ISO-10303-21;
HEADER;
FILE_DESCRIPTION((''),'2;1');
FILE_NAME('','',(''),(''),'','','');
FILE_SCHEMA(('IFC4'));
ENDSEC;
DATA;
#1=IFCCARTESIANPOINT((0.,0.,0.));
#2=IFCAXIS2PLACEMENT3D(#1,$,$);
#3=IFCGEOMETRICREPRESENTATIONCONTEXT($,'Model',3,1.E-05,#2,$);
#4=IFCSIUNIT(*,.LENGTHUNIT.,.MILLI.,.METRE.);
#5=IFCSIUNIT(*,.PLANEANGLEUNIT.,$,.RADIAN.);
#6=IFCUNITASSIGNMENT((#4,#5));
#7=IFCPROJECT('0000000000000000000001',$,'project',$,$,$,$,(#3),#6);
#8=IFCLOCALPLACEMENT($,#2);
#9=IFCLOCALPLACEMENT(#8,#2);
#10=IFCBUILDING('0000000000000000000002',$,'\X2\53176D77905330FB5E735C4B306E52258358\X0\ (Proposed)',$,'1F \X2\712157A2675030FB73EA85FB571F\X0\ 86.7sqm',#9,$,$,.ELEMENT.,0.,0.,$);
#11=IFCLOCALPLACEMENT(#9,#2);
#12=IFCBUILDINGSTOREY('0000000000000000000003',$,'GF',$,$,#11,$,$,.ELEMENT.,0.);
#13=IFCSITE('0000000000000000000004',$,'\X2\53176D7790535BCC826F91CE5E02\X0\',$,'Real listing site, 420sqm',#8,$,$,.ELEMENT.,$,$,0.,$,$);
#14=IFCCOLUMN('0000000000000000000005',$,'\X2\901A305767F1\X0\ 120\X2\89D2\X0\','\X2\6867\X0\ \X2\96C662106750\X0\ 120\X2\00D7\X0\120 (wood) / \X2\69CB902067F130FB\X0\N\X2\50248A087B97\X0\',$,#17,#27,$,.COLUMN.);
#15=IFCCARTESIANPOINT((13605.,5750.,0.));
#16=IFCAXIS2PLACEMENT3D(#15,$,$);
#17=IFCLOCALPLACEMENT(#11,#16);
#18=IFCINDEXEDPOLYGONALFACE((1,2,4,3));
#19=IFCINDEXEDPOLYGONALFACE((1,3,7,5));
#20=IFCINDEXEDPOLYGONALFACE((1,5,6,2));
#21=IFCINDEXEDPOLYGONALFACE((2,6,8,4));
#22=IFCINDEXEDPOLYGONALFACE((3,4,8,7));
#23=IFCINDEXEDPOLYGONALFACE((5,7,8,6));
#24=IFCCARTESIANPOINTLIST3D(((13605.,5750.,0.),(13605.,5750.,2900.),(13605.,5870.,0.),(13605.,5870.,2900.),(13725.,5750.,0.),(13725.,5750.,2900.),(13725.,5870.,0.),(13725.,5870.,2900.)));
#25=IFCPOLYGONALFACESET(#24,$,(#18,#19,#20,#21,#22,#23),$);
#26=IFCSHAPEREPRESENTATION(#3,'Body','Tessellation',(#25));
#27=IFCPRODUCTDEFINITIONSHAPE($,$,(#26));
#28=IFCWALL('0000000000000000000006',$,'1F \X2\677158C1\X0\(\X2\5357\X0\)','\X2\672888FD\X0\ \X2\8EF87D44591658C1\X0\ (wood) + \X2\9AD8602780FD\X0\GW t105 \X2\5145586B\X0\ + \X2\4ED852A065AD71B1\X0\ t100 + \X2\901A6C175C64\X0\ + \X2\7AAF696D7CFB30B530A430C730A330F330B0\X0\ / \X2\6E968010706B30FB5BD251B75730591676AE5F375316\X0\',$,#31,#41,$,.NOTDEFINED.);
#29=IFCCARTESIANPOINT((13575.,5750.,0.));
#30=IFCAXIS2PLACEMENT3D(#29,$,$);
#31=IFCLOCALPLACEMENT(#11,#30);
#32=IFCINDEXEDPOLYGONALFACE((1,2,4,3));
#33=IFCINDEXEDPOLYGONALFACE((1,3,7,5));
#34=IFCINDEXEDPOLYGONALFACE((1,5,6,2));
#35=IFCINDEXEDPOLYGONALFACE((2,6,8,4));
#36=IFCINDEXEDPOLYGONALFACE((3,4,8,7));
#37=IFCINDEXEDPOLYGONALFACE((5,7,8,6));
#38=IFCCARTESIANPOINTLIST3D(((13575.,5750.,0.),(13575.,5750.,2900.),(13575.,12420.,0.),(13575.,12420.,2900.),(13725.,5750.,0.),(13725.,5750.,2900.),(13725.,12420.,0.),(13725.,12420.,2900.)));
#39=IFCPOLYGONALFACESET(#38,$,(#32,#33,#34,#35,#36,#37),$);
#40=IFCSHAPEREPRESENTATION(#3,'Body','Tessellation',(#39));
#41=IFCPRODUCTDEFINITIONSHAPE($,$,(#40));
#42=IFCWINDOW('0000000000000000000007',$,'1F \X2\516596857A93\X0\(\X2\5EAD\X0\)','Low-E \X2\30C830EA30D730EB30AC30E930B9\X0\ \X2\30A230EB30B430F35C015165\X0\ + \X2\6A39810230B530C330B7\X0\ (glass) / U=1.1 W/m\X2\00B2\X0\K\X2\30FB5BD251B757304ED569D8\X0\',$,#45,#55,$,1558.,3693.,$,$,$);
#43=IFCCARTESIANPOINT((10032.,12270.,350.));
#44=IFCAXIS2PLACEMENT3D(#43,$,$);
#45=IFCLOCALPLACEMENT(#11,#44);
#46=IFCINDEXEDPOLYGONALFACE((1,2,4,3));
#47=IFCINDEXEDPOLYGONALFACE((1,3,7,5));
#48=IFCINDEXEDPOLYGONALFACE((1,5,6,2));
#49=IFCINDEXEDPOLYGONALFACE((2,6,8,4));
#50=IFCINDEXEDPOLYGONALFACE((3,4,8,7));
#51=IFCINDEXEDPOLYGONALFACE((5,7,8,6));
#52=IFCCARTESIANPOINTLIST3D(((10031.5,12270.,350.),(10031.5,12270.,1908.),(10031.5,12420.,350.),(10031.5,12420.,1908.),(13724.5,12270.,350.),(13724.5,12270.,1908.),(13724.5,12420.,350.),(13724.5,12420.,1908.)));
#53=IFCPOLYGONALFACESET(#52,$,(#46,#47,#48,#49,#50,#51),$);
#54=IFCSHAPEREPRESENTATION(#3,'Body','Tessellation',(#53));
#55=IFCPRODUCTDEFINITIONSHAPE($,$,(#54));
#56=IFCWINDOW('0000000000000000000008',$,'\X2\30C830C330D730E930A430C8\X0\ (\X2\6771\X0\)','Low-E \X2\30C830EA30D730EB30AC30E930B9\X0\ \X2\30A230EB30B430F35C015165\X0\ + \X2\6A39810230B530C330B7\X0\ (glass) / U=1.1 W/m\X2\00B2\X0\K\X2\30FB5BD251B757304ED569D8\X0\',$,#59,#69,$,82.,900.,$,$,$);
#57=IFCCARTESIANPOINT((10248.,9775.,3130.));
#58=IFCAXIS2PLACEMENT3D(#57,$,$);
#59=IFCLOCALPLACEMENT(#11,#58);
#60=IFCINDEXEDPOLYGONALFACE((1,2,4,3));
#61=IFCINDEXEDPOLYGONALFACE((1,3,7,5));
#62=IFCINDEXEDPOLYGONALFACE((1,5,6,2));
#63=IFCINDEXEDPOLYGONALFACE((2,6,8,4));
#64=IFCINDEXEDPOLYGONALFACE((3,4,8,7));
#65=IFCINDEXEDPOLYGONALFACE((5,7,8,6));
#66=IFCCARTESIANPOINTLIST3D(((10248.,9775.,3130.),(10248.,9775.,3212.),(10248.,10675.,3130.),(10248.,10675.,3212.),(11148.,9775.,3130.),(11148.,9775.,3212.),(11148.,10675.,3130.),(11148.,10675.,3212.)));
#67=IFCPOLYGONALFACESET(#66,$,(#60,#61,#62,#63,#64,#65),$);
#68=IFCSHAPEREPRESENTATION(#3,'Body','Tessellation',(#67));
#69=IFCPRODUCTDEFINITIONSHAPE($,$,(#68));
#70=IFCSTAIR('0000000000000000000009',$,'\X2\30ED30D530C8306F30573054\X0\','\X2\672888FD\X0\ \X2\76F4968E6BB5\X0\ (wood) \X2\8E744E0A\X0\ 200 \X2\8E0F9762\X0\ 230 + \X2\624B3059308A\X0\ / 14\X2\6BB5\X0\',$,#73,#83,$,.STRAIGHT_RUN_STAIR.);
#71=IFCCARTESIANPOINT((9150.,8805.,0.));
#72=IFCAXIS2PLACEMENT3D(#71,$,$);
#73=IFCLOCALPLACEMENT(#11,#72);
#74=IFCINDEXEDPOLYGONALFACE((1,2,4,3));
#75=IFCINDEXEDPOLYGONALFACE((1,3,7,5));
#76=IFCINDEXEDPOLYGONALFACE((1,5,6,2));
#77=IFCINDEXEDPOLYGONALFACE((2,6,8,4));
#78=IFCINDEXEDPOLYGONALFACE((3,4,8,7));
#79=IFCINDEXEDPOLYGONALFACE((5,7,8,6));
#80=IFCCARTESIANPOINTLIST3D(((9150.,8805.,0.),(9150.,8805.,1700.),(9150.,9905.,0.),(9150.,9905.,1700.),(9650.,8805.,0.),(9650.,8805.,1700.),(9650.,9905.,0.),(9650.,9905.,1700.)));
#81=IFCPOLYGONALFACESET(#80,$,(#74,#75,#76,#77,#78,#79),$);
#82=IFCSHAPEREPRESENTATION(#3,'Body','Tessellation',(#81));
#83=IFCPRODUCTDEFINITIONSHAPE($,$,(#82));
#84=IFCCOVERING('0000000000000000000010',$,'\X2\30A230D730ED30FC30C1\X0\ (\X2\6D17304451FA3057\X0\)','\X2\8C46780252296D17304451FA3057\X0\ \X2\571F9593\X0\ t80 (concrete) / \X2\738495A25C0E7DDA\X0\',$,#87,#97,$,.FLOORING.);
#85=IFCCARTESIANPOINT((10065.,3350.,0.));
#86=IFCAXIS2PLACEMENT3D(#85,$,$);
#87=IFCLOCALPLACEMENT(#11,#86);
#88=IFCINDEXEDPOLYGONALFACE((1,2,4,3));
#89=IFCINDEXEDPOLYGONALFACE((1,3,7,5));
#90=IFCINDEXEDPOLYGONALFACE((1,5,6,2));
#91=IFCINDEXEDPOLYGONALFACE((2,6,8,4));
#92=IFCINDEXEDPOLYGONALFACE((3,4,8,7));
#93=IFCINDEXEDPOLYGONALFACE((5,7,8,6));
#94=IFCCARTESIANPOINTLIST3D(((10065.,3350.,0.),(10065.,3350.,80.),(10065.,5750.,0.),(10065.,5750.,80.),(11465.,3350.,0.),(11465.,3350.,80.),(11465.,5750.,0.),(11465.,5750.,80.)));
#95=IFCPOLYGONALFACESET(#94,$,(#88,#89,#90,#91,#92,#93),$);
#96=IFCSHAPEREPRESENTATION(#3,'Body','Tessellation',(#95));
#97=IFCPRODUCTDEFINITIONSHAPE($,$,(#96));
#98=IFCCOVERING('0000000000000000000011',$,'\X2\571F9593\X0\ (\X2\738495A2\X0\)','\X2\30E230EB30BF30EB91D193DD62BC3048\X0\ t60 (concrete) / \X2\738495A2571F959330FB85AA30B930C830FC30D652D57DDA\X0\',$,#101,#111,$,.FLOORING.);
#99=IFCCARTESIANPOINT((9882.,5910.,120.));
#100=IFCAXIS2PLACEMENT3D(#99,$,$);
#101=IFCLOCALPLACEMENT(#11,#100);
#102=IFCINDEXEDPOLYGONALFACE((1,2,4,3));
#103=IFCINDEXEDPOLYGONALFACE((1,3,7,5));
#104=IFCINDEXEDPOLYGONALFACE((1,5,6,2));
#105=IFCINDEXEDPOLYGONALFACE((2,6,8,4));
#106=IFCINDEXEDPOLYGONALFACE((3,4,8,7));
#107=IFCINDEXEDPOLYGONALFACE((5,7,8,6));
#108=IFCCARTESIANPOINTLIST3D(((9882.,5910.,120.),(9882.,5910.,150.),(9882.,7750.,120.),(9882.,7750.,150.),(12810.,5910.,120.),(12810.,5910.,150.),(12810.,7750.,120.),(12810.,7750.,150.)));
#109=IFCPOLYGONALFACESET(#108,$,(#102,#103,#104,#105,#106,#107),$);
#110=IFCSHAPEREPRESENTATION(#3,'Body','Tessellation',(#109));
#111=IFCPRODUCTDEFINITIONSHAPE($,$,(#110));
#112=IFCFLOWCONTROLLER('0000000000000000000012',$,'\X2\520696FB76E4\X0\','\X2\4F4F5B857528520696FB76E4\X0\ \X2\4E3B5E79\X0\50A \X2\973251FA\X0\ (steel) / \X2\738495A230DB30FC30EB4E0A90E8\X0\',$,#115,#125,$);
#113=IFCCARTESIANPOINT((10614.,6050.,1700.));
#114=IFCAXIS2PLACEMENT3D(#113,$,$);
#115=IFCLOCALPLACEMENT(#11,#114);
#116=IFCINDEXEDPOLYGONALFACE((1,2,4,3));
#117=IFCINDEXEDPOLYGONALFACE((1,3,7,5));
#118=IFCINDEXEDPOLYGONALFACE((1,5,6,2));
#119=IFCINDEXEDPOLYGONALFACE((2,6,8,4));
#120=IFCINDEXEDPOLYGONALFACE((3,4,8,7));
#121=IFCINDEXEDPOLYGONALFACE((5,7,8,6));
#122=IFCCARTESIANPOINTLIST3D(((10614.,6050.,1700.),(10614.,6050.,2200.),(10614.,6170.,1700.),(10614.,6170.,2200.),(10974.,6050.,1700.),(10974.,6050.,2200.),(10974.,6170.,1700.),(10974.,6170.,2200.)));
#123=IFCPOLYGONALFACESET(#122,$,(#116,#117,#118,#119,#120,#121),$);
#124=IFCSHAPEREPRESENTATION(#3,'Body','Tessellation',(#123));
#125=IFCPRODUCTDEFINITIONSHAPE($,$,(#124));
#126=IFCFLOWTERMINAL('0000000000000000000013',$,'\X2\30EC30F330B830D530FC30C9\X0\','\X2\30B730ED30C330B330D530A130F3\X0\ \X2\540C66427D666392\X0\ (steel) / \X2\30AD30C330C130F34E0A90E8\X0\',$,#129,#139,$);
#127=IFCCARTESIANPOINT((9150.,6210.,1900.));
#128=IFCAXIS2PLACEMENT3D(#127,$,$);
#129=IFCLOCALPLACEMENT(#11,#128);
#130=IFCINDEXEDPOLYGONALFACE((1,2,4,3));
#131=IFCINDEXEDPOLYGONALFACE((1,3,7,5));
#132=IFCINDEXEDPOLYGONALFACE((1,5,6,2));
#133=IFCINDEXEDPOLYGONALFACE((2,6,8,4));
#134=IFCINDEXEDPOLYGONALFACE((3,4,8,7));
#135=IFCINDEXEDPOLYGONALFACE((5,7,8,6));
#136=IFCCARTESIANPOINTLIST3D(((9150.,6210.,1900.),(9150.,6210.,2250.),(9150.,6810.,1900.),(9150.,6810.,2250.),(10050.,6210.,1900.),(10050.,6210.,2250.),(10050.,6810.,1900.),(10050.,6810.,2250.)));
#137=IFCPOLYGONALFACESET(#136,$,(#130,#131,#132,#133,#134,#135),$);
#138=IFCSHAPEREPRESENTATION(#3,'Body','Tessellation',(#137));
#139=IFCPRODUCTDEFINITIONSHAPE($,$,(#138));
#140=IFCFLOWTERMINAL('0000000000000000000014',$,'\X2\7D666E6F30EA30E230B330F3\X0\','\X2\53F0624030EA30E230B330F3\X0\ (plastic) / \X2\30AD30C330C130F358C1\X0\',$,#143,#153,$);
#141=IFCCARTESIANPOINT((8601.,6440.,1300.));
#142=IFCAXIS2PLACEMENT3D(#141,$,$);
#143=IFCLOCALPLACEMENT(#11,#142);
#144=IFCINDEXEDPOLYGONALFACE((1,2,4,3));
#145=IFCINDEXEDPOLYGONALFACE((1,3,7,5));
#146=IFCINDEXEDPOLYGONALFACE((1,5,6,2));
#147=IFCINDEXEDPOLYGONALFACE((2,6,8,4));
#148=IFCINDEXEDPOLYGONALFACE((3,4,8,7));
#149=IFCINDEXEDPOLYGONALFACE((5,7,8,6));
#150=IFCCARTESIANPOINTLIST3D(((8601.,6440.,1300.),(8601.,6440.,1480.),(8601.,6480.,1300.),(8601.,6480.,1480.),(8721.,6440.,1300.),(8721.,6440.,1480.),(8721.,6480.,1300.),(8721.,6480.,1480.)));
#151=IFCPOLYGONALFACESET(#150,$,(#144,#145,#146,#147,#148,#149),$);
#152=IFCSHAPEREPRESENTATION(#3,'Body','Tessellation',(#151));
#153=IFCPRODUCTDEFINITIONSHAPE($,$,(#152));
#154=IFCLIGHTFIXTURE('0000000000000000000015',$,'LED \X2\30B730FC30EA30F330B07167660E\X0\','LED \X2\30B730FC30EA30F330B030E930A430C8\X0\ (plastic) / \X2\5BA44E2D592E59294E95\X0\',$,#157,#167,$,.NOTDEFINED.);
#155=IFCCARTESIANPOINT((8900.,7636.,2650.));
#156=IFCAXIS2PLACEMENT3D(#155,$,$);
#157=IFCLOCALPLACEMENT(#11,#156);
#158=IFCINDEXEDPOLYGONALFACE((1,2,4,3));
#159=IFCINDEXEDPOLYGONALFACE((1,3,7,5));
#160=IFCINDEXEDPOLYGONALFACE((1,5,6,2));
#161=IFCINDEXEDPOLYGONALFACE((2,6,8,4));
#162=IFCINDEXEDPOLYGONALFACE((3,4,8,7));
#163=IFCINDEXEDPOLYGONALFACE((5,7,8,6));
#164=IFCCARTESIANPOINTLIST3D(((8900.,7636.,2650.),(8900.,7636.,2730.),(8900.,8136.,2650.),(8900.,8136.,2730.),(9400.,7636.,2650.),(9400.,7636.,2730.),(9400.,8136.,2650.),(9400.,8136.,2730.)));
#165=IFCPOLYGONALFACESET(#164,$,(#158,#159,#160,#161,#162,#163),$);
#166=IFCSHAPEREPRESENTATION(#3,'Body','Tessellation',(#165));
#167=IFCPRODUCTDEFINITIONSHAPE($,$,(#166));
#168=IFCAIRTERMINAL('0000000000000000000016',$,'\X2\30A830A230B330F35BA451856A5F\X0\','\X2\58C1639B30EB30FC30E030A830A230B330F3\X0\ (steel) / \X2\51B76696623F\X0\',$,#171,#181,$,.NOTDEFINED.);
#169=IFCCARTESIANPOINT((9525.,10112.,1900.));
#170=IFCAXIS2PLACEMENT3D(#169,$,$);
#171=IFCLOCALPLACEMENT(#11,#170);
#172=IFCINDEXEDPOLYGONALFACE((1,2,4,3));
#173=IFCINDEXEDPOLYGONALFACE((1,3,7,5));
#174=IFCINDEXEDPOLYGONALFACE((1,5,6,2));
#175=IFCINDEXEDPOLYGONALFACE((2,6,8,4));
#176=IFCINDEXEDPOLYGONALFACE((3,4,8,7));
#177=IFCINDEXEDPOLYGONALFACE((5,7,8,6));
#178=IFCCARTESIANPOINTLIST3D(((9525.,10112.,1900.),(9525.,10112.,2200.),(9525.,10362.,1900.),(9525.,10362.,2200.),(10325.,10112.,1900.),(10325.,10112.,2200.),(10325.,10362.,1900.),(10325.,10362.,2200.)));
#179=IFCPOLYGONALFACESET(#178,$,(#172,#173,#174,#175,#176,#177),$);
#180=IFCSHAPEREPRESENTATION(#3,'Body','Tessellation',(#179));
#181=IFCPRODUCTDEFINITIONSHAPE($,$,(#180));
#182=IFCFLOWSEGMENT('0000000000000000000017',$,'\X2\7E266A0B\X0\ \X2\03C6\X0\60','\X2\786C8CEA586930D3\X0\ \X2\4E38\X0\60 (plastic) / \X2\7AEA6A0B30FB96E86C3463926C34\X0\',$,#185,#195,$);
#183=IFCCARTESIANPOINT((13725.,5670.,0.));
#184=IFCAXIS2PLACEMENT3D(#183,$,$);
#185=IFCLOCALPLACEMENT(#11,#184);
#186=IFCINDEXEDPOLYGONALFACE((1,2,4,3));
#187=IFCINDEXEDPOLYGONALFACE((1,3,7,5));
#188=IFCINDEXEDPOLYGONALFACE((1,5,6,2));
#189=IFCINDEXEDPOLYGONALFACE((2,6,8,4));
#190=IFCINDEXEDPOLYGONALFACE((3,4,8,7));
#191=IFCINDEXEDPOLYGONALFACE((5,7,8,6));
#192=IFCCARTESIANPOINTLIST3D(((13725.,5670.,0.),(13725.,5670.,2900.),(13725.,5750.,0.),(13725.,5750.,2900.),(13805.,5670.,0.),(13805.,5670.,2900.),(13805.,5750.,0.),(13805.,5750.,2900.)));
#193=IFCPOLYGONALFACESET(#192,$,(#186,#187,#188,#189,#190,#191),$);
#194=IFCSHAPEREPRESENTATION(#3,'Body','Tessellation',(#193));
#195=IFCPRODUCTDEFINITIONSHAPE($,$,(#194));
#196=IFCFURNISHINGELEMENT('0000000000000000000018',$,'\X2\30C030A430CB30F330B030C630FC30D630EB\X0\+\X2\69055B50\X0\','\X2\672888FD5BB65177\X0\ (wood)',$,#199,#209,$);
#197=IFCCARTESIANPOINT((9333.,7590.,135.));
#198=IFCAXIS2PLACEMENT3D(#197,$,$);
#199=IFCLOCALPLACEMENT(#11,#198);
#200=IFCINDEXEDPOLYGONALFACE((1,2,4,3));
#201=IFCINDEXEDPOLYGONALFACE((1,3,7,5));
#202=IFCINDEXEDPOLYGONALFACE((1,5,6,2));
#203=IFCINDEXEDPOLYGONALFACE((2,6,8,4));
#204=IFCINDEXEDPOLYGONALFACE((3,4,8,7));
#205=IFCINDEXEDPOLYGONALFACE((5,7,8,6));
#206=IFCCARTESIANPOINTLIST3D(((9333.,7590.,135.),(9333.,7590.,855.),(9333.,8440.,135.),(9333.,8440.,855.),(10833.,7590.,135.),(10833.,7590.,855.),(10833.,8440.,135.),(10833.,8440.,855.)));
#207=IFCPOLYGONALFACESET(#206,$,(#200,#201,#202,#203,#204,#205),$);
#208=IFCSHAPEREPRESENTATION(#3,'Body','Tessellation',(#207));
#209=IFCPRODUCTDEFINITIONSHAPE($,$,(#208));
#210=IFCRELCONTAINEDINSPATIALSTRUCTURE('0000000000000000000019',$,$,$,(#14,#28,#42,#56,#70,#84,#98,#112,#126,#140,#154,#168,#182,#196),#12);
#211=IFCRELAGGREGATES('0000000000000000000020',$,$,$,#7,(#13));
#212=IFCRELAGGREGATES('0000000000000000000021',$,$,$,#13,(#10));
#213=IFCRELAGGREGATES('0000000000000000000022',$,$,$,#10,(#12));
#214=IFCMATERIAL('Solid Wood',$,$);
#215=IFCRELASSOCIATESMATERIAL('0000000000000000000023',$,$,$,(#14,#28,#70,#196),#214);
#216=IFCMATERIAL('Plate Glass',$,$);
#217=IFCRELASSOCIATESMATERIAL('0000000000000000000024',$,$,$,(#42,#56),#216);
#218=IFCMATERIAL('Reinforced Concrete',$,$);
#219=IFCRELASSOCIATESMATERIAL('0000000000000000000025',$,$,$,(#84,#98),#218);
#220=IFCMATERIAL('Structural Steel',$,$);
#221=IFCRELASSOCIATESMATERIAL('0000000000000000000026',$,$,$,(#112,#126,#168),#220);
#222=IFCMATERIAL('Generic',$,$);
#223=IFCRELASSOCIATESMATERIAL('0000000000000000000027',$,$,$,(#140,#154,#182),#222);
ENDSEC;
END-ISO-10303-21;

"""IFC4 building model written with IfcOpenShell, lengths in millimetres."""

from ifc_helpers import new_model, si_unit, frame, frame_2d, origin, place, context, project, spatial, rectangle, extrude, material, element, fill, save


model = new_model("IFC4")

# Units and contexts
model_context = context("Model", 3, precision=1e-05, world=origin())
ifc_project = project(units=[si_unit("LENGTHUNIT", "METRE", prefix="MILLI"), si_unit("PLANEANGLEUNIT", "RADIAN")], contexts=[model_context])

# Site, building, storey
site_placement = place(None, origin())
site = spatial("IfcSite", under=ifc_project, at=site_placement, Name="北海道富良野市", ObjectType="Real listing site, 420sqm", CompositionType="ELEMENT", RefElevation=0.0)
building_placement = place(site_placement, origin())
building = spatial("IfcBuilding", under=site, at=building_placement, Name="北海道・平屋の別荘 (Proposed)", ObjectType="1F 無垢材・珪藻土 86.7sqm", CompositionType="ELEMENT", ElevationOfRefHeight=0.0, ElevationOfTerrain=0.0)
storey_placement = place(building_placement, origin())
storey = spatial("IfcBuildingStorey", under=building, at=storey_placement, Name="GF", CompositionType="ELEMENT", Elevation=0.0)

# Column
ifc_material_1 = material(Name="Solid Wood")
column_1_placement = place(storey_placement, frame((13605.0, 5750.0, 0.0)))
element("IfcColumn", 1, at=column_1_placement, inside=storey, material=ifc_material_1, Name="通し柱 120角", Description="桧 集成材 120×120 (wood) / 構造柱・N値計算", PredefinedType="COLUMN", context=model_context, shape_type="SweptSolid", body=[
    extrude(rectangle(XDim=120.0, YDim=120.0, at=frame_2d((60.0, 60.0))), frame((13605.0, 5750.0, 0.0)), (0.0, 0.0, 1.0), 2900.0),
])

# Wall, opening, window
wall_1_placement = place(storey_placement, frame((13575.0, 5750.0, 0.0)))
wall_1 = element("IfcWall", 2, at=wall_1_placement, inside=storey, material=ifc_material_1, Name="1F 東壁(南)", Description="木製 軸組外壁 (wood) + 高性能GW t105 充填 + 付加断熱 t100 + 通気層 + 窯業系サイディング / 準耐火・寒冷地外皮強化", PredefinedType="NOTDEFINED", context=model_context, shape_type="SweptSolid", body=[
    extrude(rectangle(XDim=150.0, YDim=6670.0, at=frame_2d((75.0, 3335.0))), frame((13575.0, 5750.0, 0.0)), (0.0, 0.0, 1.0), 2900.0),
])
opening_placement = place(storey_placement, frame((10032.0, 12270.0, 350.0)))
opening = element("IfcOpeningElement", 3, at=opening_placement, cuts=wall_1, PredefinedType="NOTDEFINED", context=model_context, shape_type="SweptSolid", body=[
    extrude(rectangle(XDim=3693.0, YDim=150.0, at=frame_2d((1846.0, 75.0))), frame((10032.0, 12270.0, 350.0)), (0.0, 0.0, 1.0), 1558.0),
])
ifc_material_2 = material(Name="Plate Glass")
window_1_placement = place(storey_placement, frame((10032.0, 12270.0, 350.0)))
window_1 = element("IfcWindow", 4, at=window_1_placement, inside=storey, material=ifc_material_2, Name="1F 入隅窓(庭)", Description="Low-E トリプルガラス アルゴン封入 + 樹脂サッシ (glass) / U=1.1 W/m²K・寒冷地仕様", OverallHeight=1558.0, OverallWidth=3693.0, context=model_context, shape_type="SweptSolid", body=[
    extrude(rectangle(XDim=3693.0, YDim=150.0, at=frame_2d((1846.0, 75.0))), frame((10032.0, 12270.0, 350.0)), (0.0, 0.0, 1.0), 1558.0),
])
fill(opening, window_1)

# Window
window_2_placement = place(storey_placement, frame((10248.0, 9775.0, 3130.0)))
element("IfcWindow", 5, at=window_2_placement, inside=storey, material=ifc_material_2, Name="トップライト (東)", Description="Low-E トリプルガラス アルゴン封入 + 樹脂サッシ (glass) / U=1.1 W/m²K・寒冷地仕様", OverallHeight=82.0, OverallWidth=900.0, context=model_context, shape_type="SweptSolid", body=[
    extrude(rectangle(XDim=900.0, YDim=900.0, at=frame_2d((450.0, 450.0))), frame((10248.0, 9775.0, 3130.0)), (0.0, 0.0, 1.0), 82.0),
])

# Stair
stair_placement = place(storey_placement, frame((9150.0, 8805.0, 0.0)))
element("IfcStair", 6, at=stair_placement, inside=storey, material=ifc_material_1, Name="ロフトはしご", Description="木製 直階段 (wood) 蹴上 200 踏面 230 + 手すり / 14段", PredefinedType="STRAIGHT_RUN_STAIR", context=model_context, shape_type="SweptSolid", body=[
    extrude(rectangle(XDim=500.0, YDim=1100.0, at=frame_2d((250.0, 550.0))), frame((9150.0, 8805.0, 0.0)), (0.0, 0.0, 1.0), 1700.0),
])

# Coverings
ifc_material_3 = material(Name="Reinforced Concrete")
covering_1_placement = place(storey_placement, frame((10065.0, 3350.0, 0.0)))
element("IfcCovering", 7, at=covering_1_placement, inside=storey, material=ifc_material_3, Name="アプローチ (洗い出し)", Description="豆砂利洗い出し 土間 t80 (concrete) / 玄関導線", PredefinedType="FLOORING", context=model_context, shape_type="SweptSolid", body=[
    extrude(rectangle(XDim=1400.0, YDim=2400.0, at=frame_2d((700.0, 1200.0))), frame((10065.0, 3350.0, 0.0)), (0.0, 0.0, 1.0), 80.0),
])
covering_2_placement = place(storey_placement, frame((9882.0, 5910.0, 120.0)))
element("IfcCovering", 8, at=covering_2_placement, inside=storey, material=ifc_material_3, Name="土間 (玄関)", Description="モルタル金鏝押え t60 (concrete) / 玄関土間・薪ストーブ動線", PredefinedType="FLOORING", context=model_context, shape_type="SweptSolid", body=[
    extrude(rectangle(XDim=2928.0, YDim=1840.0, at=frame_2d((1464.0, 920.0))), frame((9882.0, 5910.0, 120.0)), (0.0, 0.0, 1.0), 30.0),
])

# Flow controller
ifc_material_4 = material(Name="Structural Steel")
flow_controller_placement = place(storey_placement, frame((10614.0, 6050.0, 1700.0)))
element("IfcFlowController", 9, at=flow_controller_placement, inside=storey, material=ifc_material_4, Name="分電盤", Description="住宅用分電盤 主幹50A 露出 (steel) / 玄関ホール上部", context=model_context, shape_type="SweptSolid", body=[
    extrude(rectangle(XDim=360.0, YDim=120.0, at=frame_2d((180.0, 60.0))), frame((10614.0, 6050.0, 1700.0)), (0.0, 0.0, 1.0), 500.0),
])

# Flow terminals
flow_terminal_1_placement = place(storey_placement, frame((9150.0, 6210.0, 1900.0)))
element("IfcFlowTerminal", 10, at=flow_terminal_1_placement, inside=storey, material=ifc_material_4, Name="レンジフード", Description="シロッコファン 同時給排 (steel) / キッチン上部", context=model_context, shape_type="SweptSolid", body=[
    extrude(rectangle(XDim=900.0, YDim=600.0, at=frame_2d((450.0, 300.0))), frame((9150.0, 6210.0, 1900.0)), (0.0, 0.0, 1.0), 350.0),
])
ifc_material_5 = material(Name="Generic")
flow_terminal_2_placement = place(storey_placement, frame((8601.0, 6440.0, 1300.0)))
element("IfcFlowTerminal", 11, at=flow_terminal_2_placement, inside=storey, material=ifc_material_5, Name="給湯リモコン", Description="台所リモコン (plastic) / キッチン壁", context=model_context, shape_type="SweptSolid", body=[
    extrude(rectangle(XDim=120.0, YDim=40.0, at=frame_2d((60.0, 20.0))), frame((8601.0, 6440.0, 1300.0)), (0.0, 0.0, 1.0), 180.0),
])

# Light fixture
light_fixture_placement = place(storey_placement, frame((8900.0, 7636.0, 2650.0)))
element("IfcLightFixture", 12, at=light_fixture_placement, inside=storey, material=ifc_material_5, Name="LED シーリング照明", Description="LED シーリングライト (plastic) / 室中央天井", PredefinedType="NOTDEFINED", context=model_context, shape_type="SweptSolid", body=[
    extrude(rectangle(XDim=500.0, YDim=500.0, at=frame_2d((250.0, 250.0))), frame((8900.0, 7636.0, 2650.0)), (0.0, 0.0, 1.0), 80.0),
])

# Air terminal
air_terminal_placement = place(storey_placement, frame((9525.0, 10112.0, 1900.0)))
element("IfcAirTerminal", 13, at=air_terminal_placement, inside=storey, material=ifc_material_4, Name="エアコン室内機", Description="壁掛ルームエアコン (steel) / 冷暖房", PredefinedType="NOTDEFINED", context=model_context, shape_type="SweptSolid", body=[
    extrude(rectangle(XDim=800.0, YDim=250.0, at=frame_2d((400.0, 125.0))), frame((9525.0, 10112.0, 1900.0)), (0.0, 0.0, 1.0), 300.0),
])

# Flow segment
flow_segment_placement = place(storey_placement, frame((13725.0, 5670.0, 0.0)))
element("IfcFlowSegment", 14, at=flow_segment_placement, inside=storey, material=ifc_material_5, Name="縦樋 φ60", Description="硬質塩ビ 丸60 (plastic) / 竪樋・雨水排水", context=model_context, shape_type="SweptSolid", body=[
    extrude(rectangle(XDim=80.0, YDim=80.0, at=frame_2d((40.0, 40.0))), frame((13725.0, 5670.0, 0.0)), (0.0, 0.0, 1.0), 2900.0),
])

# Furnishing element
furnishing_1_placement = place(storey_placement, frame((9333.0, 7590.0, 135.0)))
element("IfcFurnishingElement", 15, at=furnishing_1_placement, inside=storey, material=ifc_material_1, Name="ダイニングテーブル+椅子", Description="木製家具 (wood)", context=model_context, shape_type="SweptSolid", body=[
    extrude(rectangle(XDim=1500.0, YDim=850.0, at=frame_2d((750.0, 425.0))), frame((9333.0, 7590.0, 135.0)), (0.0, 0.0, 1.0), 720.0),
])

save(model, "model.ifc")
